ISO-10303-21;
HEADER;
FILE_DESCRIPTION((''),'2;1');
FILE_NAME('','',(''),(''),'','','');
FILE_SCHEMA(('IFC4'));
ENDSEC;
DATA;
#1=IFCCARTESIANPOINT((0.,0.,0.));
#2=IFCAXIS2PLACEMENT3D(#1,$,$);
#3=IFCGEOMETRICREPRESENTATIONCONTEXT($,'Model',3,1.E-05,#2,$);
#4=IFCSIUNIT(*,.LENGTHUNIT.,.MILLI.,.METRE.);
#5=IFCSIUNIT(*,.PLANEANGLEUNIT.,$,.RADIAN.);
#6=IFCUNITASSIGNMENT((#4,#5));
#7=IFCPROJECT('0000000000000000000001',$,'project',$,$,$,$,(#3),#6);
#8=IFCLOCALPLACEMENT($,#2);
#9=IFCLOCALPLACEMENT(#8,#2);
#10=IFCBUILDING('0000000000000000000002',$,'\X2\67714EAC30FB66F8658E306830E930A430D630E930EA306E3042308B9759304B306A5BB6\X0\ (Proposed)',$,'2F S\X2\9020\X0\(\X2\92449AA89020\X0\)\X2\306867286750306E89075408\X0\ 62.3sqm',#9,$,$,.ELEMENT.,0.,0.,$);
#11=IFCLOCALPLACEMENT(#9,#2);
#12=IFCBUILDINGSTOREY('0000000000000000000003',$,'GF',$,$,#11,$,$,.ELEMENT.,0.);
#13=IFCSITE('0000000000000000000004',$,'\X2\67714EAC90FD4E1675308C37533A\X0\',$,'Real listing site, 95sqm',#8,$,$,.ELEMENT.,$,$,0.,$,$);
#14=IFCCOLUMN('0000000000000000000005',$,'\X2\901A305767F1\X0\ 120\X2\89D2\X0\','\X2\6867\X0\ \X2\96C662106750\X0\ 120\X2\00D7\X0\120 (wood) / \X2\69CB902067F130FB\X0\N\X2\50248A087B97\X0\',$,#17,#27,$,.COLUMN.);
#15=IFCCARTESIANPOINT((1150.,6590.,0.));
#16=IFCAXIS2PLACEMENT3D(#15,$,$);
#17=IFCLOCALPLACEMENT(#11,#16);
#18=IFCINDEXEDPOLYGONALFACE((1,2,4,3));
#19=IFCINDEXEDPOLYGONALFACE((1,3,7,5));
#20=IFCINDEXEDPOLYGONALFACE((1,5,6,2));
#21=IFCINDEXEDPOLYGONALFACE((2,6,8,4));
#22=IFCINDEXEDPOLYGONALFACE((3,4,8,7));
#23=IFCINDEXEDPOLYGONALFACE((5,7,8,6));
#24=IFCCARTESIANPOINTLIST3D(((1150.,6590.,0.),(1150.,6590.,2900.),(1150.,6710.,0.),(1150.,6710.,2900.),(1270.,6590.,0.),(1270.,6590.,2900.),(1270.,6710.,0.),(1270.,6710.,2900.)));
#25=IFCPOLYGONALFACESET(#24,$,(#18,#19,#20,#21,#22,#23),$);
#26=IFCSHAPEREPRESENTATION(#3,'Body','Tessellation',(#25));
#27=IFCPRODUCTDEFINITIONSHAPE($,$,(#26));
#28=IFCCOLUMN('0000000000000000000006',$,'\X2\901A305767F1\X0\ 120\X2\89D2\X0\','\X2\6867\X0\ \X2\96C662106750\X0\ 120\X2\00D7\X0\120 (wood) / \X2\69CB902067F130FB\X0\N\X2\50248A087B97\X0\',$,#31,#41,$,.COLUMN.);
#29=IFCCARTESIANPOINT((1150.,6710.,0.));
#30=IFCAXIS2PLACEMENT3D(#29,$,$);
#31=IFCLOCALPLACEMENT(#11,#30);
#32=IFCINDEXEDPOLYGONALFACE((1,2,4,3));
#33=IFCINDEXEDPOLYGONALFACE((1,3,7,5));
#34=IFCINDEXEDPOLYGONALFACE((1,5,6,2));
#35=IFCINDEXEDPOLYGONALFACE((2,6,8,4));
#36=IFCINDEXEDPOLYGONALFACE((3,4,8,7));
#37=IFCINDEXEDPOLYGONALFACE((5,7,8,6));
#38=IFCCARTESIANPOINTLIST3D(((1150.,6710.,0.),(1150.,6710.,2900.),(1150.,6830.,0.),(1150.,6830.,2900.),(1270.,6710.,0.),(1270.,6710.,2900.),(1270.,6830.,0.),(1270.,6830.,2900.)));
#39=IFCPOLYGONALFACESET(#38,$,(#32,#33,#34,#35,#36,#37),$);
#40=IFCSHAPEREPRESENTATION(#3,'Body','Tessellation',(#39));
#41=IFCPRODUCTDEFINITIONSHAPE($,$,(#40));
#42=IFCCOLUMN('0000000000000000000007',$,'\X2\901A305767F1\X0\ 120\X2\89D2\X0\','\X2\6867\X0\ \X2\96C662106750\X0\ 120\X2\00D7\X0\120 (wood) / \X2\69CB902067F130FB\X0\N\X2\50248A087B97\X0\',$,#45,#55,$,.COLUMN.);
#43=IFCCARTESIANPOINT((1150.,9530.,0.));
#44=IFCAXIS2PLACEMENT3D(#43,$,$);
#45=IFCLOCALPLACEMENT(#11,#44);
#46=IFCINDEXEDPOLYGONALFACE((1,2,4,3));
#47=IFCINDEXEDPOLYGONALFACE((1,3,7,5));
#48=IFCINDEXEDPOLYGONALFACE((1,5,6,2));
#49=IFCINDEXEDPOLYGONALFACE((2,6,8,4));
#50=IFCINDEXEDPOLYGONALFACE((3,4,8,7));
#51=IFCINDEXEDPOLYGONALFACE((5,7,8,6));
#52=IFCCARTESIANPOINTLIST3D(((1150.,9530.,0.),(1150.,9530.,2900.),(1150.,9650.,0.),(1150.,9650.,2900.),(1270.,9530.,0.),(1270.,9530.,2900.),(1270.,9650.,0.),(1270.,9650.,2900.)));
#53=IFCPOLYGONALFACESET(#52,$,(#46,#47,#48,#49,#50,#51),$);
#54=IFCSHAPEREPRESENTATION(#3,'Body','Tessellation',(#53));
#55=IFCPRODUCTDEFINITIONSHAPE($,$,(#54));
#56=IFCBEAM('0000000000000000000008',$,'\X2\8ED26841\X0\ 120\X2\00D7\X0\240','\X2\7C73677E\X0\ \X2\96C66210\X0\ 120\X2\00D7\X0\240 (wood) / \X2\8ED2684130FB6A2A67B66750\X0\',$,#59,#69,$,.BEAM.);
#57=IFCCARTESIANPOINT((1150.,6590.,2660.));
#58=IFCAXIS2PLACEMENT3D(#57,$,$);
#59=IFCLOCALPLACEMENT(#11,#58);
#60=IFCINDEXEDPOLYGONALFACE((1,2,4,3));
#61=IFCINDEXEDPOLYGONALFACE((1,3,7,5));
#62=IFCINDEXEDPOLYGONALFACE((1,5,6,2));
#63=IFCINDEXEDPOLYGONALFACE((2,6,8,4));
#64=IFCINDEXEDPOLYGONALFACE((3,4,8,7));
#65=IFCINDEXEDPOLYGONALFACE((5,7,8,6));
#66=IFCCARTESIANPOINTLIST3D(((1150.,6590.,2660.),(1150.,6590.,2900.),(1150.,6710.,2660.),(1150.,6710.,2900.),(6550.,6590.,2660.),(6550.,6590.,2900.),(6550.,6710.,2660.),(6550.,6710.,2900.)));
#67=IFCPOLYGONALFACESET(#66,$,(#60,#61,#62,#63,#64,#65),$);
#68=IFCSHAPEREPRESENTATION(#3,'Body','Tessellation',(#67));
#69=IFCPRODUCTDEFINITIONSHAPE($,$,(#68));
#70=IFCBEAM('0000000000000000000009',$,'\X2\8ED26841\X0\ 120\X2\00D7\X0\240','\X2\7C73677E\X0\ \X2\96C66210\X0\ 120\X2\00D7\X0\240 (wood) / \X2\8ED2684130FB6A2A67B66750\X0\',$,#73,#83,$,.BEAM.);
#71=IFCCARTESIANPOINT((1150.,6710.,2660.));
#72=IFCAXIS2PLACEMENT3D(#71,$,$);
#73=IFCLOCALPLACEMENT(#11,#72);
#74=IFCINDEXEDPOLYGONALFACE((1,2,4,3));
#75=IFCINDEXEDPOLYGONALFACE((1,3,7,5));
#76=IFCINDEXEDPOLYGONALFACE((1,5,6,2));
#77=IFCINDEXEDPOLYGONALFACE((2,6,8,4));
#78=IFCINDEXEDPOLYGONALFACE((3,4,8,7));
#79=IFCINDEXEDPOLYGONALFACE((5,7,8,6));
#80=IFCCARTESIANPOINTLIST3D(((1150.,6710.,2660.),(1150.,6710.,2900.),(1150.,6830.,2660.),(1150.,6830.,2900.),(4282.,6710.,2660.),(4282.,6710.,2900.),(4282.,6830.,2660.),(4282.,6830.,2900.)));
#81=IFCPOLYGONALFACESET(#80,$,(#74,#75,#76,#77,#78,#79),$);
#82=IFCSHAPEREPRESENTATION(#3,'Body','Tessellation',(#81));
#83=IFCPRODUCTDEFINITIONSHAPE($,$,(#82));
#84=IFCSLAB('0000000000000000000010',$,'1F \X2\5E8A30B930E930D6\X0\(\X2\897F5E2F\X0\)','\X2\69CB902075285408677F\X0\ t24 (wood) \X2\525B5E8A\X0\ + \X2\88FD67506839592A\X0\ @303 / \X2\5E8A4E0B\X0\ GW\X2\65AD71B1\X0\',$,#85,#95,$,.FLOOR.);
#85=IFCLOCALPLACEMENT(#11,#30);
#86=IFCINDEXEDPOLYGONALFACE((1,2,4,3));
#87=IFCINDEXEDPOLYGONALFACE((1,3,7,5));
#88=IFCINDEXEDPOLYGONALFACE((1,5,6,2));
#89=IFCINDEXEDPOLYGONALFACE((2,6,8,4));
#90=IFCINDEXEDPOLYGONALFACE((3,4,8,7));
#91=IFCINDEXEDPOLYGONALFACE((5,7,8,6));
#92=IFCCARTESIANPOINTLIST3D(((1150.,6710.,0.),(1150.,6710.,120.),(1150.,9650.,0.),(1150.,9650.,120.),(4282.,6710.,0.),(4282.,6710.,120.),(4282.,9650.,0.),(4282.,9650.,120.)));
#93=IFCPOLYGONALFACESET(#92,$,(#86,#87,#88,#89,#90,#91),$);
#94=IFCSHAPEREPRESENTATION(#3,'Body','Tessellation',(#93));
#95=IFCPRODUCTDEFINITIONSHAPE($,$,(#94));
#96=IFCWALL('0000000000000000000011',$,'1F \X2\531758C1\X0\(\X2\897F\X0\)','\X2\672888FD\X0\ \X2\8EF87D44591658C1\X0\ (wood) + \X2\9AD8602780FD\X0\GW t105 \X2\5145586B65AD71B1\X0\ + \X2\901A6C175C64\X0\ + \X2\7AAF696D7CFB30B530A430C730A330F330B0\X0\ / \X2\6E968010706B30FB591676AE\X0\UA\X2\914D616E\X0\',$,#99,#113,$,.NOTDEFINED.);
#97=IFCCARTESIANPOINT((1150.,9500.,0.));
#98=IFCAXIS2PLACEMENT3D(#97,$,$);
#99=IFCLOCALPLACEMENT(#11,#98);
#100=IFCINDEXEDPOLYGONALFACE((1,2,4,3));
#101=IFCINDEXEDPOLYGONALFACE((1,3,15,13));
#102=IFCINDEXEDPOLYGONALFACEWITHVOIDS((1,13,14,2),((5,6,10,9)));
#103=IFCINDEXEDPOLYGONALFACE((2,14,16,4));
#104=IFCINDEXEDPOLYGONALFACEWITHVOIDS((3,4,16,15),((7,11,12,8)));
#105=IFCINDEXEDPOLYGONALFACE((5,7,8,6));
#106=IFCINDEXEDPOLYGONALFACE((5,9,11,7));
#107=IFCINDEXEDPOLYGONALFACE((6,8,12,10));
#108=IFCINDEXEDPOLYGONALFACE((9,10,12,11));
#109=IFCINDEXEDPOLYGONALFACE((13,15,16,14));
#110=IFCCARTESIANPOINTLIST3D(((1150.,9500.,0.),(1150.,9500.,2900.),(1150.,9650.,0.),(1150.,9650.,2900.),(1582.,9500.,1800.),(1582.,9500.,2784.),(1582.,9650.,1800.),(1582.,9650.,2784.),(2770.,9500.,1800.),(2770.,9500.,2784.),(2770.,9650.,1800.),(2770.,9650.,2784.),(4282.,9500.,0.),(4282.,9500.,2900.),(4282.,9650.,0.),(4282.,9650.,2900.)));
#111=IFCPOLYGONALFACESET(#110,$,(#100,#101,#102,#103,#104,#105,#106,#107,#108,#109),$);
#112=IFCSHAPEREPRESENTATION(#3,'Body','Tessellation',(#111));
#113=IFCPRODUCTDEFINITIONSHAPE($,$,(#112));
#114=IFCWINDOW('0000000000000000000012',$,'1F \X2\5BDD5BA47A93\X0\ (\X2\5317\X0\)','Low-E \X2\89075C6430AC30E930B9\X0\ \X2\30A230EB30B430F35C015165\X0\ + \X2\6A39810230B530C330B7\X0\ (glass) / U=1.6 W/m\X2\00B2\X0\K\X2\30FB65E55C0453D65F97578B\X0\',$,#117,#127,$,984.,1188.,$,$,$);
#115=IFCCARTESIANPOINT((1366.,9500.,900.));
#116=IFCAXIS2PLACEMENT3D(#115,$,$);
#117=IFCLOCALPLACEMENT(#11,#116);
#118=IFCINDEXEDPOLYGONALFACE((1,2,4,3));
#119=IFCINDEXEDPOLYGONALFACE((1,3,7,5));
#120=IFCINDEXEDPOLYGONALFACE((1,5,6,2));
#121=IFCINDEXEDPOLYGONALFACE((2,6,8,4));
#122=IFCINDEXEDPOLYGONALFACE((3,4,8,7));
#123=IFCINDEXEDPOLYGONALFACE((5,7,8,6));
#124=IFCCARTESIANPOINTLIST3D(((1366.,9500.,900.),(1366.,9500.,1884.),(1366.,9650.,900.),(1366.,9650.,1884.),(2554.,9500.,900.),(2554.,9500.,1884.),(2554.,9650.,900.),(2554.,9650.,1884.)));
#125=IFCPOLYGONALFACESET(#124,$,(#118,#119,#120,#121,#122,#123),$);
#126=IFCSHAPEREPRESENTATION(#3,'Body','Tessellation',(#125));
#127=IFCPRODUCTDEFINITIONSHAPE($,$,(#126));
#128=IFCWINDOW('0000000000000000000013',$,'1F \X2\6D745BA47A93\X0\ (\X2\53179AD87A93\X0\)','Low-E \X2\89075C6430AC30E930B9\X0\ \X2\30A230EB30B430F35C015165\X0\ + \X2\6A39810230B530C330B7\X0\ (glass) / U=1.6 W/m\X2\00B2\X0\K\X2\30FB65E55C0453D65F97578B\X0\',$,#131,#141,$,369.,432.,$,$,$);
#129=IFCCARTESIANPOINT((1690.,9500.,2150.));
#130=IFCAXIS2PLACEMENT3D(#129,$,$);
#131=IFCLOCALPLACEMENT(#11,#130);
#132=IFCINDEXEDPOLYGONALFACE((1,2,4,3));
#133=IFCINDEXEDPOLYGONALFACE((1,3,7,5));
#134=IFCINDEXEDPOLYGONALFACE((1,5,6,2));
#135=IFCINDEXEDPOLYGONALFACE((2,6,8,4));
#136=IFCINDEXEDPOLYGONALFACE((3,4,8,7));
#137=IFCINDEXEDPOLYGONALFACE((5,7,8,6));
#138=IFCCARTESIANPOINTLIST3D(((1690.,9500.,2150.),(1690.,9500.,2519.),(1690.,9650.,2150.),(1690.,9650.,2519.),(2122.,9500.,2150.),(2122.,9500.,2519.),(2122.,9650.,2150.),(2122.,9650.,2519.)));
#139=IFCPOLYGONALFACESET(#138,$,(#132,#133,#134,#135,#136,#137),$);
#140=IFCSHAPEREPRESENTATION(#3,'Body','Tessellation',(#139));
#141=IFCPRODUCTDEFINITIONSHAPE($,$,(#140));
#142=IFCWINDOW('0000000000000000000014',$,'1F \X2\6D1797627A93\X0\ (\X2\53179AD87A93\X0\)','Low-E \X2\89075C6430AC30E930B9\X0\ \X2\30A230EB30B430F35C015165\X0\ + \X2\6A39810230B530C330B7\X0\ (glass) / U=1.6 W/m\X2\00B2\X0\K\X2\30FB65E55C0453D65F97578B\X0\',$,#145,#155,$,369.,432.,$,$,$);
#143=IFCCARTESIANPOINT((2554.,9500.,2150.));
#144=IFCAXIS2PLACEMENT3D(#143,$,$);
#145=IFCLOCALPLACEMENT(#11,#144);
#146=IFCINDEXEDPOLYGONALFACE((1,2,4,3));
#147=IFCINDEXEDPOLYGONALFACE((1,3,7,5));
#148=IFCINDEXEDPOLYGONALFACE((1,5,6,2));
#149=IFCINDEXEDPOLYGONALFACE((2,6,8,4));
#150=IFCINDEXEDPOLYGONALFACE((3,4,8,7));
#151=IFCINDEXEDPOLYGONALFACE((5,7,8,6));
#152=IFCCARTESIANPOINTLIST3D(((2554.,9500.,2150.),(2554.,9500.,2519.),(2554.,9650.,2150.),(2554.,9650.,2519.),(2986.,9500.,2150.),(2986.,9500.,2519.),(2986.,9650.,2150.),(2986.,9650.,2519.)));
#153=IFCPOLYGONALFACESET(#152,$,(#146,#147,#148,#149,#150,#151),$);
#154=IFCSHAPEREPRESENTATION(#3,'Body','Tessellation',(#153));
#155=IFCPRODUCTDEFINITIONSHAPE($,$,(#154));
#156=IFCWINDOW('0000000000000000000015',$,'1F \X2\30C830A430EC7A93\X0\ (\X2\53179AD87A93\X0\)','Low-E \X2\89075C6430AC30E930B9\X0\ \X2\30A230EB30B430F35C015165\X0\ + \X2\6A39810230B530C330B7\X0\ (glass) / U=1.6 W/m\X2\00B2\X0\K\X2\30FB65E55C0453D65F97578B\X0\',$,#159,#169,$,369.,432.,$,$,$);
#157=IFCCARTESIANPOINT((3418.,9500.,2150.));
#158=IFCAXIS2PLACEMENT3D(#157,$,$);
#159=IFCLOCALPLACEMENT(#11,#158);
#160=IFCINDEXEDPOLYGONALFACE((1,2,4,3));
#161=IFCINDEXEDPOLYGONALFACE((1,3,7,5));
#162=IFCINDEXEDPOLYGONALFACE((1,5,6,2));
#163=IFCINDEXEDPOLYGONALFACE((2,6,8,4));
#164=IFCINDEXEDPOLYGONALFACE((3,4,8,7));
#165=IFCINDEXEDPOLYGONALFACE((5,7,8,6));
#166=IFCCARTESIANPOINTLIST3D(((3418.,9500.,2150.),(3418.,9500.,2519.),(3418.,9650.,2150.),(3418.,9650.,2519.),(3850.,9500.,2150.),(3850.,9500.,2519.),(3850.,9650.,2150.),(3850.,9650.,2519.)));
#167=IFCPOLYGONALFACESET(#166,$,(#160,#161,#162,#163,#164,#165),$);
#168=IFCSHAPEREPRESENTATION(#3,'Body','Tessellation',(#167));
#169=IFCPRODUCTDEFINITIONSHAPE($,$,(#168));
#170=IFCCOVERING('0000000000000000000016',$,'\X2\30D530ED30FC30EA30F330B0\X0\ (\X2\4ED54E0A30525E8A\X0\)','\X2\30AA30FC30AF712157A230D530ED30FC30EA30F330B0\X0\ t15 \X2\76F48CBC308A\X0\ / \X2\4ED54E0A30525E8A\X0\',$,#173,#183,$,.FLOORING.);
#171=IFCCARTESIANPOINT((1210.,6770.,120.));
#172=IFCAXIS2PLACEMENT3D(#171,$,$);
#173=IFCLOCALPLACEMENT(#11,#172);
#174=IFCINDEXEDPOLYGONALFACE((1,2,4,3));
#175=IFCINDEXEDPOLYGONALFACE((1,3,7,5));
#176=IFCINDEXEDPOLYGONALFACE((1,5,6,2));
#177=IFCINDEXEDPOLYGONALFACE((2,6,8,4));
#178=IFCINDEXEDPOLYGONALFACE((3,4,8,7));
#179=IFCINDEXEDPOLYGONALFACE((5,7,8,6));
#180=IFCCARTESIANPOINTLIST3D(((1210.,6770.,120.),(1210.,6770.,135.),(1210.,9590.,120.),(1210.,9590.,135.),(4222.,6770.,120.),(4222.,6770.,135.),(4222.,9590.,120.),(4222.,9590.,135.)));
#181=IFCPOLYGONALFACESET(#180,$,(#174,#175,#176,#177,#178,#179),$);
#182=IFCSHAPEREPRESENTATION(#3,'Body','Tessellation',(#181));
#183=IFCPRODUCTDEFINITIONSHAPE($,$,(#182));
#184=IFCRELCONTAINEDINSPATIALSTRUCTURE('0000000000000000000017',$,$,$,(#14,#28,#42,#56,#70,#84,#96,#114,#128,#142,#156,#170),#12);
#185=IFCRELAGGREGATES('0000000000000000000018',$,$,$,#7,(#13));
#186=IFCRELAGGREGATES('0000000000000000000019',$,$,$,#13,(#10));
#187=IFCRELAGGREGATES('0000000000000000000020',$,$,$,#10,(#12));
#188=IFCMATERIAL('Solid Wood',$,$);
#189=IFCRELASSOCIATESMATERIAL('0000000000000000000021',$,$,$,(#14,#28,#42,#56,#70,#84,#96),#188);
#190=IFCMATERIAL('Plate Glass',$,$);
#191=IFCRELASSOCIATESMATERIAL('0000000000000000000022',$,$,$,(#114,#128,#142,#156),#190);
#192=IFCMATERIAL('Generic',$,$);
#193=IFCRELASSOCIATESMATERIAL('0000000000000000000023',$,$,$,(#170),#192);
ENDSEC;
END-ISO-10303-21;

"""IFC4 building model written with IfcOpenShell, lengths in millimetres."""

from ifc_helpers import new_model, si_unit, frame, frame_2d, origin, place, context, project, spatial, rectangle, extrude, material, element, fill, save


model = new_model("IFC4")

# Units and contexts
model_context = context("Model", 3, precision=1e-05, world=origin())
ifc_project = project(units=[si_unit("LENGTHUNIT", "METRE", prefix="MILLI"), si_unit("PLANEANGLEUNIT", "RADIAN")], contexts=[model_context])

# Site, building, storey
site_placement = place(None, origin())
site = spatial("IfcSite", under=ifc_project, at=site_placement, Name="東京都世田谷区", ObjectType="Real listing site, 95sqm", CompositionType="ELEMENT", RefElevation=0.0)
building_placement = place(site_placement, origin())
building = spatial("IfcBuilding", under=site, at=building_placement, Name="東京・書斎とライブラリのある静かな家 (Proposed)", ObjectType="2F S造(鉄骨造)と木材の複合 62.3sqm", CompositionType="ELEMENT", ElevationOfRefHeight=0.0, ElevationOfTerrain=0.0)
storey_placement = place(building_placement, origin())
storey = spatial("IfcBuildingStorey", under=building, at=storey_placement, Name="GF", CompositionType="ELEMENT", Elevation=0.0)

# Columns
ifc_material_1 = material(Name="Solid Wood")
column_1_placement = place(storey_placement, frame((1150.0, 6590.0, 0.0)))
element("IfcColumn", 1, at=column_1_placement, inside=storey, material=ifc_material_1, Name="通し柱 120角", Description="桧 集成材 120×120 (wood) / 構造柱・N値計算", PredefinedType="COLUMN", context=model_context, shape_type="SweptSolid", body=[
    extrude(rectangle(XDim=120.0, YDim=120.0, at=frame_2d((60.0, 60.0))), frame((1150.0, 6590.0, 0.0)), (0.0, 0.0, 1.0), 2900.0),
])
column_2_placement = place(storey_placement, frame((1150.0, 6710.0, 0.0)))
element("IfcColumn", 2, at=column_2_placement, inside=storey, material=ifc_material_1, Name="通し柱 120角", Description="桧 集成材 120×120 (wood) / 構造柱・N値計算", PredefinedType="COLUMN", context=model_context, shape_type="SweptSolid", body=[
    extrude(rectangle(XDim=120.0, YDim=120.0, at=frame_2d((60.0, 60.0))), frame((1150.0, 6710.0, 0.0)), (0.0, 0.0, 1.0), 2900.0),
])
column_3_placement = place(storey_placement, frame((1150.0, 9530.0, 0.0)))
element("IfcColumn", 3, at=column_3_placement, inside=storey, material=ifc_material_1, Name="通し柱 120角", Description="桧 集成材 120×120 (wood) / 構造柱・N値計算", PredefinedType="COLUMN", context=model_context, shape_type="SweptSolid", body=[
    extrude(rectangle(XDim=120.0, YDim=120.0, at=frame_2d((60.0, 60.0))), frame((1150.0, 9530.0, 0.0)), (0.0, 0.0, 1.0), 2900.0),
])

# Beams
beam_1_placement = place(storey_placement, frame((1150.0, 6590.0, 2660.0)))
element("IfcBeam", 4, at=beam_1_placement, inside=storey, material=ifc_material_1, Name="軒桁 120×240", Description="米松 集成 120×240 (wood) / 軒桁・横架材", PredefinedType="BEAM", context=model_context, shape_type="SweptSolid", body=[
    extrude(rectangle(XDim=5400.0, YDim=120.0, at=frame_2d((2700.0, 60.0))), frame((1150.0, 6590.0, 2660.0)), (0.0, 0.0, 1.0), 240.0),
])
beam_2_placement = place(storey_placement, frame((1150.0, 6710.0, 2660.0)))
element("IfcBeam", 5, at=beam_2_placement, inside=storey, material=ifc_material_1, Name="軒桁 120×240", Description="米松 集成 120×240 (wood) / 軒桁・横架材", PredefinedType="BEAM", context=model_context, shape_type="SweptSolid", body=[
    extrude(rectangle(XDim=3132.0, YDim=120.0, at=frame_2d((1566.0, 60.0))), frame((1150.0, 6710.0, 2660.0)), (0.0, 0.0, 1.0), 240.0),
])

# Slab
slab_placement = place(storey_placement, frame((1150.0, 6710.0, 0.0)))
element("IfcSlab", 6, at=slab_placement, inside=storey, material=ifc_material_1, Name="1F 床スラブ(西帯)", Description="構造用合板 t24 (wood) 剛床 + 製材根太 @303 / 床下 GW断熱", PredefinedType="FLOOR", context=model_context, shape_type="SweptSolid", body=[
    extrude(rectangle(XDim=3132.0, YDim=2940.0, at=frame_2d((1566.0, 1470.0))), frame((1150.0, 6710.0, 0.0)), (0.0, 0.0, 1.0), 120.0),
])

# Wall, openings, windows
wall_1_placement = place(storey_placement, frame((1150.0, 9500.0, 0.0)))
wall_1 = element("IfcWall", 7, at=wall_1_placement, inside=storey, material=ifc_material_1, Name="1F 北壁(西)", Description="木製 軸組外壁 (wood) + 高性能GW t105 充填断熱 + 通気層 + 窯業系サイディング / 準耐火・外皮UA配慮", PredefinedType="NOTDEFINED", context=model_context, shape_type="SweptSolid", body=[
    extrude(rectangle(XDim=3132.0, YDim=150.0, at=frame_2d((1566.0, 75.0))), frame((1150.0, 9500.0, 0.0)), (0.0, 0.0, 1.0), 2900.0),
])
opening_1_placement = place(storey_placement, frame((1366.0, 9500.0, 900.0)))
opening_1 = element("IfcOpeningElement", 8, at=opening_1_placement, cuts=wall_1, PredefinedType="NOTDEFINED", context=model_context, shape_type="SweptSolid", body=[
    extrude(rectangle(XDim=1188.0, YDim=150.0, at=frame_2d((594.0, 75.0))), frame((1366.0, 9500.0, 900.0)), (0.0, 0.0, 1.0), 984.0),
])
opening_2_placement = place(storey_placement, frame((1690.0, 9500.0, 2150.0)))
opening_2 = element("IfcOpeningElement", 9, at=opening_2_placement, cuts=wall_1, PredefinedType="NOTDEFINED", context=model_context, shape_type="SweptSolid", body=[
    extrude(rectangle(XDim=432.0, YDim=150.0, at=frame_2d((216.0, 75.0))), frame((1690.0, 9500.0, 2150.0)), (0.0, 0.0, 1.0), 369.0),
])
opening_3_placement = place(storey_placement, frame((2554.0, 9500.0, 2150.0)))
opening_3 = element("IfcOpeningElement", 10, at=opening_3_placement, cuts=wall_1, PredefinedType="NOTDEFINED", context=model_context, shape_type="SweptSolid", body=[
    extrude(rectangle(XDim=432.0, YDim=150.0, at=frame_2d((216.0, 75.0))), frame((2554.0, 9500.0, 2150.0)), (0.0, 0.0, 1.0), 369.0),
])
opening_4_placement = place(storey_placement, frame((3418.0, 9500.0, 2150.0)))
opening_4 = element("IfcOpeningElement", 11, at=opening_4_placement, cuts=wall_1, PredefinedType="NOTDEFINED", context=model_context, shape_type="SweptSolid", body=[
    extrude(rectangle(XDim=432.0, YDim=150.0, at=frame_2d((216.0, 75.0))), frame((3418.0, 9500.0, 2150.0)), (0.0, 0.0, 1.0), 369.0),
])
ifc_material_2 = material(Name="Plate Glass")
window_1_placement = place(storey_placement, frame((1366.0, 9500.0, 900.0)))
window_1 = element("IfcWindow", 12, at=window_1_placement, inside=storey, material=ifc_material_2, Name="1F 寝室窓 (北)", Description="Low-E 複層ガラス アルゴン封入 + 樹脂サッシ (glass) / U=1.6 W/m²K・日射取得型", OverallHeight=984.0, OverallWidth=1188.0, context=model_context, shape_type="SweptSolid", body=[
    extrude(rectangle(XDim=1188.0, YDim=150.0, at=frame_2d((594.0, 75.0))), frame((1366.0, 9500.0, 900.0)), (0.0, 0.0, 1.0), 984.0),
])
fill(opening_1, window_1)
window_2_placement = place(storey_placement, frame((1690.0, 9500.0, 2150.0)))
window_2 = element("IfcWindow", 13, at=window_2_placement, inside=storey, material=ifc_material_2, Name="1F 浴室窓 (北高窓)", Description="Low-E 複層ガラス アルゴン封入 + 樹脂サッシ (glass) / U=1.6 W/m²K・日射取得型", OverallHeight=369.0, OverallWidth=432.0, context=model_context, shape_type="SweptSolid", body=[
    extrude(rectangle(XDim=432.0, YDim=150.0, at=frame_2d((216.0, 75.0))), frame((1690.0, 9500.0, 2150.0)), (0.0, 0.0, 1.0), 369.0),
])
fill(opening_2, window_2)
window_3_placement = place(storey_placement, frame((2554.0, 9500.0, 2150.0)))
window_3 = element("IfcWindow", 14, at=window_3_placement, inside=storey, material=ifc_material_2, Name="1F 洗面窓 (北高窓)", Description="Low-E 複層ガラス アルゴン封入 + 樹脂サッシ (glass) / U=1.6 W/m²K・日射取得型", OverallHeight=369.0, OverallWidth=432.0, context=model_context, shape_type="SweptSolid", body=[
    extrude(rectangle(XDim=432.0, YDim=150.0, at=frame_2d((216.0, 75.0))), frame((2554.0, 9500.0, 2150.0)), (0.0, 0.0, 1.0), 369.0),
])
fill(opening_3, window_3)
window_4_placement = place(storey_placement, frame((3418.0, 9500.0, 2150.0)))
window_4 = element("IfcWindow", 15, at=window_4_placement, inside=storey, material=ifc_material_2, Name="1F トイレ窓 (北高窓)", Description="Low-E 複層ガラス アルゴン封入 + 樹脂サッシ (glass) / U=1.6 W/m²K・日射取得型", OverallHeight=369.0, OverallWidth=432.0, context=model_context, shape_type="SweptSolid", body=[
    extrude(rectangle(XDim=432.0, YDim=150.0, at=frame_2d((216.0, 75.0))), frame((3418.0, 9500.0, 2150.0)), (0.0, 0.0, 1.0), 369.0),
])
fill(opening_4, window_4)

# Covering
ifc_material_3 = material(Name="Generic")
covering_placement = place(storey_placement, frame((1210.0, 6770.0, 120.0)))
element("IfcCovering", 16, at=covering_placement, inside=storey, material=ifc_material_3, Name="フローリング (仕上げ床)", Description="オーク無垢フローリング t15 直貼り / 仕上げ床", PredefinedType="FLOORING", context=model_context, shape_type="SweptSolid", body=[
    extrude(rectangle(XDim=3012.0, YDim=2820.0, at=frame_2d((1506.0, 1410.0))), frame((1210.0, 6770.0, 120.0)), (0.0, 0.0, 1.0), 15.0),
])

save(model, "model.ifc")
